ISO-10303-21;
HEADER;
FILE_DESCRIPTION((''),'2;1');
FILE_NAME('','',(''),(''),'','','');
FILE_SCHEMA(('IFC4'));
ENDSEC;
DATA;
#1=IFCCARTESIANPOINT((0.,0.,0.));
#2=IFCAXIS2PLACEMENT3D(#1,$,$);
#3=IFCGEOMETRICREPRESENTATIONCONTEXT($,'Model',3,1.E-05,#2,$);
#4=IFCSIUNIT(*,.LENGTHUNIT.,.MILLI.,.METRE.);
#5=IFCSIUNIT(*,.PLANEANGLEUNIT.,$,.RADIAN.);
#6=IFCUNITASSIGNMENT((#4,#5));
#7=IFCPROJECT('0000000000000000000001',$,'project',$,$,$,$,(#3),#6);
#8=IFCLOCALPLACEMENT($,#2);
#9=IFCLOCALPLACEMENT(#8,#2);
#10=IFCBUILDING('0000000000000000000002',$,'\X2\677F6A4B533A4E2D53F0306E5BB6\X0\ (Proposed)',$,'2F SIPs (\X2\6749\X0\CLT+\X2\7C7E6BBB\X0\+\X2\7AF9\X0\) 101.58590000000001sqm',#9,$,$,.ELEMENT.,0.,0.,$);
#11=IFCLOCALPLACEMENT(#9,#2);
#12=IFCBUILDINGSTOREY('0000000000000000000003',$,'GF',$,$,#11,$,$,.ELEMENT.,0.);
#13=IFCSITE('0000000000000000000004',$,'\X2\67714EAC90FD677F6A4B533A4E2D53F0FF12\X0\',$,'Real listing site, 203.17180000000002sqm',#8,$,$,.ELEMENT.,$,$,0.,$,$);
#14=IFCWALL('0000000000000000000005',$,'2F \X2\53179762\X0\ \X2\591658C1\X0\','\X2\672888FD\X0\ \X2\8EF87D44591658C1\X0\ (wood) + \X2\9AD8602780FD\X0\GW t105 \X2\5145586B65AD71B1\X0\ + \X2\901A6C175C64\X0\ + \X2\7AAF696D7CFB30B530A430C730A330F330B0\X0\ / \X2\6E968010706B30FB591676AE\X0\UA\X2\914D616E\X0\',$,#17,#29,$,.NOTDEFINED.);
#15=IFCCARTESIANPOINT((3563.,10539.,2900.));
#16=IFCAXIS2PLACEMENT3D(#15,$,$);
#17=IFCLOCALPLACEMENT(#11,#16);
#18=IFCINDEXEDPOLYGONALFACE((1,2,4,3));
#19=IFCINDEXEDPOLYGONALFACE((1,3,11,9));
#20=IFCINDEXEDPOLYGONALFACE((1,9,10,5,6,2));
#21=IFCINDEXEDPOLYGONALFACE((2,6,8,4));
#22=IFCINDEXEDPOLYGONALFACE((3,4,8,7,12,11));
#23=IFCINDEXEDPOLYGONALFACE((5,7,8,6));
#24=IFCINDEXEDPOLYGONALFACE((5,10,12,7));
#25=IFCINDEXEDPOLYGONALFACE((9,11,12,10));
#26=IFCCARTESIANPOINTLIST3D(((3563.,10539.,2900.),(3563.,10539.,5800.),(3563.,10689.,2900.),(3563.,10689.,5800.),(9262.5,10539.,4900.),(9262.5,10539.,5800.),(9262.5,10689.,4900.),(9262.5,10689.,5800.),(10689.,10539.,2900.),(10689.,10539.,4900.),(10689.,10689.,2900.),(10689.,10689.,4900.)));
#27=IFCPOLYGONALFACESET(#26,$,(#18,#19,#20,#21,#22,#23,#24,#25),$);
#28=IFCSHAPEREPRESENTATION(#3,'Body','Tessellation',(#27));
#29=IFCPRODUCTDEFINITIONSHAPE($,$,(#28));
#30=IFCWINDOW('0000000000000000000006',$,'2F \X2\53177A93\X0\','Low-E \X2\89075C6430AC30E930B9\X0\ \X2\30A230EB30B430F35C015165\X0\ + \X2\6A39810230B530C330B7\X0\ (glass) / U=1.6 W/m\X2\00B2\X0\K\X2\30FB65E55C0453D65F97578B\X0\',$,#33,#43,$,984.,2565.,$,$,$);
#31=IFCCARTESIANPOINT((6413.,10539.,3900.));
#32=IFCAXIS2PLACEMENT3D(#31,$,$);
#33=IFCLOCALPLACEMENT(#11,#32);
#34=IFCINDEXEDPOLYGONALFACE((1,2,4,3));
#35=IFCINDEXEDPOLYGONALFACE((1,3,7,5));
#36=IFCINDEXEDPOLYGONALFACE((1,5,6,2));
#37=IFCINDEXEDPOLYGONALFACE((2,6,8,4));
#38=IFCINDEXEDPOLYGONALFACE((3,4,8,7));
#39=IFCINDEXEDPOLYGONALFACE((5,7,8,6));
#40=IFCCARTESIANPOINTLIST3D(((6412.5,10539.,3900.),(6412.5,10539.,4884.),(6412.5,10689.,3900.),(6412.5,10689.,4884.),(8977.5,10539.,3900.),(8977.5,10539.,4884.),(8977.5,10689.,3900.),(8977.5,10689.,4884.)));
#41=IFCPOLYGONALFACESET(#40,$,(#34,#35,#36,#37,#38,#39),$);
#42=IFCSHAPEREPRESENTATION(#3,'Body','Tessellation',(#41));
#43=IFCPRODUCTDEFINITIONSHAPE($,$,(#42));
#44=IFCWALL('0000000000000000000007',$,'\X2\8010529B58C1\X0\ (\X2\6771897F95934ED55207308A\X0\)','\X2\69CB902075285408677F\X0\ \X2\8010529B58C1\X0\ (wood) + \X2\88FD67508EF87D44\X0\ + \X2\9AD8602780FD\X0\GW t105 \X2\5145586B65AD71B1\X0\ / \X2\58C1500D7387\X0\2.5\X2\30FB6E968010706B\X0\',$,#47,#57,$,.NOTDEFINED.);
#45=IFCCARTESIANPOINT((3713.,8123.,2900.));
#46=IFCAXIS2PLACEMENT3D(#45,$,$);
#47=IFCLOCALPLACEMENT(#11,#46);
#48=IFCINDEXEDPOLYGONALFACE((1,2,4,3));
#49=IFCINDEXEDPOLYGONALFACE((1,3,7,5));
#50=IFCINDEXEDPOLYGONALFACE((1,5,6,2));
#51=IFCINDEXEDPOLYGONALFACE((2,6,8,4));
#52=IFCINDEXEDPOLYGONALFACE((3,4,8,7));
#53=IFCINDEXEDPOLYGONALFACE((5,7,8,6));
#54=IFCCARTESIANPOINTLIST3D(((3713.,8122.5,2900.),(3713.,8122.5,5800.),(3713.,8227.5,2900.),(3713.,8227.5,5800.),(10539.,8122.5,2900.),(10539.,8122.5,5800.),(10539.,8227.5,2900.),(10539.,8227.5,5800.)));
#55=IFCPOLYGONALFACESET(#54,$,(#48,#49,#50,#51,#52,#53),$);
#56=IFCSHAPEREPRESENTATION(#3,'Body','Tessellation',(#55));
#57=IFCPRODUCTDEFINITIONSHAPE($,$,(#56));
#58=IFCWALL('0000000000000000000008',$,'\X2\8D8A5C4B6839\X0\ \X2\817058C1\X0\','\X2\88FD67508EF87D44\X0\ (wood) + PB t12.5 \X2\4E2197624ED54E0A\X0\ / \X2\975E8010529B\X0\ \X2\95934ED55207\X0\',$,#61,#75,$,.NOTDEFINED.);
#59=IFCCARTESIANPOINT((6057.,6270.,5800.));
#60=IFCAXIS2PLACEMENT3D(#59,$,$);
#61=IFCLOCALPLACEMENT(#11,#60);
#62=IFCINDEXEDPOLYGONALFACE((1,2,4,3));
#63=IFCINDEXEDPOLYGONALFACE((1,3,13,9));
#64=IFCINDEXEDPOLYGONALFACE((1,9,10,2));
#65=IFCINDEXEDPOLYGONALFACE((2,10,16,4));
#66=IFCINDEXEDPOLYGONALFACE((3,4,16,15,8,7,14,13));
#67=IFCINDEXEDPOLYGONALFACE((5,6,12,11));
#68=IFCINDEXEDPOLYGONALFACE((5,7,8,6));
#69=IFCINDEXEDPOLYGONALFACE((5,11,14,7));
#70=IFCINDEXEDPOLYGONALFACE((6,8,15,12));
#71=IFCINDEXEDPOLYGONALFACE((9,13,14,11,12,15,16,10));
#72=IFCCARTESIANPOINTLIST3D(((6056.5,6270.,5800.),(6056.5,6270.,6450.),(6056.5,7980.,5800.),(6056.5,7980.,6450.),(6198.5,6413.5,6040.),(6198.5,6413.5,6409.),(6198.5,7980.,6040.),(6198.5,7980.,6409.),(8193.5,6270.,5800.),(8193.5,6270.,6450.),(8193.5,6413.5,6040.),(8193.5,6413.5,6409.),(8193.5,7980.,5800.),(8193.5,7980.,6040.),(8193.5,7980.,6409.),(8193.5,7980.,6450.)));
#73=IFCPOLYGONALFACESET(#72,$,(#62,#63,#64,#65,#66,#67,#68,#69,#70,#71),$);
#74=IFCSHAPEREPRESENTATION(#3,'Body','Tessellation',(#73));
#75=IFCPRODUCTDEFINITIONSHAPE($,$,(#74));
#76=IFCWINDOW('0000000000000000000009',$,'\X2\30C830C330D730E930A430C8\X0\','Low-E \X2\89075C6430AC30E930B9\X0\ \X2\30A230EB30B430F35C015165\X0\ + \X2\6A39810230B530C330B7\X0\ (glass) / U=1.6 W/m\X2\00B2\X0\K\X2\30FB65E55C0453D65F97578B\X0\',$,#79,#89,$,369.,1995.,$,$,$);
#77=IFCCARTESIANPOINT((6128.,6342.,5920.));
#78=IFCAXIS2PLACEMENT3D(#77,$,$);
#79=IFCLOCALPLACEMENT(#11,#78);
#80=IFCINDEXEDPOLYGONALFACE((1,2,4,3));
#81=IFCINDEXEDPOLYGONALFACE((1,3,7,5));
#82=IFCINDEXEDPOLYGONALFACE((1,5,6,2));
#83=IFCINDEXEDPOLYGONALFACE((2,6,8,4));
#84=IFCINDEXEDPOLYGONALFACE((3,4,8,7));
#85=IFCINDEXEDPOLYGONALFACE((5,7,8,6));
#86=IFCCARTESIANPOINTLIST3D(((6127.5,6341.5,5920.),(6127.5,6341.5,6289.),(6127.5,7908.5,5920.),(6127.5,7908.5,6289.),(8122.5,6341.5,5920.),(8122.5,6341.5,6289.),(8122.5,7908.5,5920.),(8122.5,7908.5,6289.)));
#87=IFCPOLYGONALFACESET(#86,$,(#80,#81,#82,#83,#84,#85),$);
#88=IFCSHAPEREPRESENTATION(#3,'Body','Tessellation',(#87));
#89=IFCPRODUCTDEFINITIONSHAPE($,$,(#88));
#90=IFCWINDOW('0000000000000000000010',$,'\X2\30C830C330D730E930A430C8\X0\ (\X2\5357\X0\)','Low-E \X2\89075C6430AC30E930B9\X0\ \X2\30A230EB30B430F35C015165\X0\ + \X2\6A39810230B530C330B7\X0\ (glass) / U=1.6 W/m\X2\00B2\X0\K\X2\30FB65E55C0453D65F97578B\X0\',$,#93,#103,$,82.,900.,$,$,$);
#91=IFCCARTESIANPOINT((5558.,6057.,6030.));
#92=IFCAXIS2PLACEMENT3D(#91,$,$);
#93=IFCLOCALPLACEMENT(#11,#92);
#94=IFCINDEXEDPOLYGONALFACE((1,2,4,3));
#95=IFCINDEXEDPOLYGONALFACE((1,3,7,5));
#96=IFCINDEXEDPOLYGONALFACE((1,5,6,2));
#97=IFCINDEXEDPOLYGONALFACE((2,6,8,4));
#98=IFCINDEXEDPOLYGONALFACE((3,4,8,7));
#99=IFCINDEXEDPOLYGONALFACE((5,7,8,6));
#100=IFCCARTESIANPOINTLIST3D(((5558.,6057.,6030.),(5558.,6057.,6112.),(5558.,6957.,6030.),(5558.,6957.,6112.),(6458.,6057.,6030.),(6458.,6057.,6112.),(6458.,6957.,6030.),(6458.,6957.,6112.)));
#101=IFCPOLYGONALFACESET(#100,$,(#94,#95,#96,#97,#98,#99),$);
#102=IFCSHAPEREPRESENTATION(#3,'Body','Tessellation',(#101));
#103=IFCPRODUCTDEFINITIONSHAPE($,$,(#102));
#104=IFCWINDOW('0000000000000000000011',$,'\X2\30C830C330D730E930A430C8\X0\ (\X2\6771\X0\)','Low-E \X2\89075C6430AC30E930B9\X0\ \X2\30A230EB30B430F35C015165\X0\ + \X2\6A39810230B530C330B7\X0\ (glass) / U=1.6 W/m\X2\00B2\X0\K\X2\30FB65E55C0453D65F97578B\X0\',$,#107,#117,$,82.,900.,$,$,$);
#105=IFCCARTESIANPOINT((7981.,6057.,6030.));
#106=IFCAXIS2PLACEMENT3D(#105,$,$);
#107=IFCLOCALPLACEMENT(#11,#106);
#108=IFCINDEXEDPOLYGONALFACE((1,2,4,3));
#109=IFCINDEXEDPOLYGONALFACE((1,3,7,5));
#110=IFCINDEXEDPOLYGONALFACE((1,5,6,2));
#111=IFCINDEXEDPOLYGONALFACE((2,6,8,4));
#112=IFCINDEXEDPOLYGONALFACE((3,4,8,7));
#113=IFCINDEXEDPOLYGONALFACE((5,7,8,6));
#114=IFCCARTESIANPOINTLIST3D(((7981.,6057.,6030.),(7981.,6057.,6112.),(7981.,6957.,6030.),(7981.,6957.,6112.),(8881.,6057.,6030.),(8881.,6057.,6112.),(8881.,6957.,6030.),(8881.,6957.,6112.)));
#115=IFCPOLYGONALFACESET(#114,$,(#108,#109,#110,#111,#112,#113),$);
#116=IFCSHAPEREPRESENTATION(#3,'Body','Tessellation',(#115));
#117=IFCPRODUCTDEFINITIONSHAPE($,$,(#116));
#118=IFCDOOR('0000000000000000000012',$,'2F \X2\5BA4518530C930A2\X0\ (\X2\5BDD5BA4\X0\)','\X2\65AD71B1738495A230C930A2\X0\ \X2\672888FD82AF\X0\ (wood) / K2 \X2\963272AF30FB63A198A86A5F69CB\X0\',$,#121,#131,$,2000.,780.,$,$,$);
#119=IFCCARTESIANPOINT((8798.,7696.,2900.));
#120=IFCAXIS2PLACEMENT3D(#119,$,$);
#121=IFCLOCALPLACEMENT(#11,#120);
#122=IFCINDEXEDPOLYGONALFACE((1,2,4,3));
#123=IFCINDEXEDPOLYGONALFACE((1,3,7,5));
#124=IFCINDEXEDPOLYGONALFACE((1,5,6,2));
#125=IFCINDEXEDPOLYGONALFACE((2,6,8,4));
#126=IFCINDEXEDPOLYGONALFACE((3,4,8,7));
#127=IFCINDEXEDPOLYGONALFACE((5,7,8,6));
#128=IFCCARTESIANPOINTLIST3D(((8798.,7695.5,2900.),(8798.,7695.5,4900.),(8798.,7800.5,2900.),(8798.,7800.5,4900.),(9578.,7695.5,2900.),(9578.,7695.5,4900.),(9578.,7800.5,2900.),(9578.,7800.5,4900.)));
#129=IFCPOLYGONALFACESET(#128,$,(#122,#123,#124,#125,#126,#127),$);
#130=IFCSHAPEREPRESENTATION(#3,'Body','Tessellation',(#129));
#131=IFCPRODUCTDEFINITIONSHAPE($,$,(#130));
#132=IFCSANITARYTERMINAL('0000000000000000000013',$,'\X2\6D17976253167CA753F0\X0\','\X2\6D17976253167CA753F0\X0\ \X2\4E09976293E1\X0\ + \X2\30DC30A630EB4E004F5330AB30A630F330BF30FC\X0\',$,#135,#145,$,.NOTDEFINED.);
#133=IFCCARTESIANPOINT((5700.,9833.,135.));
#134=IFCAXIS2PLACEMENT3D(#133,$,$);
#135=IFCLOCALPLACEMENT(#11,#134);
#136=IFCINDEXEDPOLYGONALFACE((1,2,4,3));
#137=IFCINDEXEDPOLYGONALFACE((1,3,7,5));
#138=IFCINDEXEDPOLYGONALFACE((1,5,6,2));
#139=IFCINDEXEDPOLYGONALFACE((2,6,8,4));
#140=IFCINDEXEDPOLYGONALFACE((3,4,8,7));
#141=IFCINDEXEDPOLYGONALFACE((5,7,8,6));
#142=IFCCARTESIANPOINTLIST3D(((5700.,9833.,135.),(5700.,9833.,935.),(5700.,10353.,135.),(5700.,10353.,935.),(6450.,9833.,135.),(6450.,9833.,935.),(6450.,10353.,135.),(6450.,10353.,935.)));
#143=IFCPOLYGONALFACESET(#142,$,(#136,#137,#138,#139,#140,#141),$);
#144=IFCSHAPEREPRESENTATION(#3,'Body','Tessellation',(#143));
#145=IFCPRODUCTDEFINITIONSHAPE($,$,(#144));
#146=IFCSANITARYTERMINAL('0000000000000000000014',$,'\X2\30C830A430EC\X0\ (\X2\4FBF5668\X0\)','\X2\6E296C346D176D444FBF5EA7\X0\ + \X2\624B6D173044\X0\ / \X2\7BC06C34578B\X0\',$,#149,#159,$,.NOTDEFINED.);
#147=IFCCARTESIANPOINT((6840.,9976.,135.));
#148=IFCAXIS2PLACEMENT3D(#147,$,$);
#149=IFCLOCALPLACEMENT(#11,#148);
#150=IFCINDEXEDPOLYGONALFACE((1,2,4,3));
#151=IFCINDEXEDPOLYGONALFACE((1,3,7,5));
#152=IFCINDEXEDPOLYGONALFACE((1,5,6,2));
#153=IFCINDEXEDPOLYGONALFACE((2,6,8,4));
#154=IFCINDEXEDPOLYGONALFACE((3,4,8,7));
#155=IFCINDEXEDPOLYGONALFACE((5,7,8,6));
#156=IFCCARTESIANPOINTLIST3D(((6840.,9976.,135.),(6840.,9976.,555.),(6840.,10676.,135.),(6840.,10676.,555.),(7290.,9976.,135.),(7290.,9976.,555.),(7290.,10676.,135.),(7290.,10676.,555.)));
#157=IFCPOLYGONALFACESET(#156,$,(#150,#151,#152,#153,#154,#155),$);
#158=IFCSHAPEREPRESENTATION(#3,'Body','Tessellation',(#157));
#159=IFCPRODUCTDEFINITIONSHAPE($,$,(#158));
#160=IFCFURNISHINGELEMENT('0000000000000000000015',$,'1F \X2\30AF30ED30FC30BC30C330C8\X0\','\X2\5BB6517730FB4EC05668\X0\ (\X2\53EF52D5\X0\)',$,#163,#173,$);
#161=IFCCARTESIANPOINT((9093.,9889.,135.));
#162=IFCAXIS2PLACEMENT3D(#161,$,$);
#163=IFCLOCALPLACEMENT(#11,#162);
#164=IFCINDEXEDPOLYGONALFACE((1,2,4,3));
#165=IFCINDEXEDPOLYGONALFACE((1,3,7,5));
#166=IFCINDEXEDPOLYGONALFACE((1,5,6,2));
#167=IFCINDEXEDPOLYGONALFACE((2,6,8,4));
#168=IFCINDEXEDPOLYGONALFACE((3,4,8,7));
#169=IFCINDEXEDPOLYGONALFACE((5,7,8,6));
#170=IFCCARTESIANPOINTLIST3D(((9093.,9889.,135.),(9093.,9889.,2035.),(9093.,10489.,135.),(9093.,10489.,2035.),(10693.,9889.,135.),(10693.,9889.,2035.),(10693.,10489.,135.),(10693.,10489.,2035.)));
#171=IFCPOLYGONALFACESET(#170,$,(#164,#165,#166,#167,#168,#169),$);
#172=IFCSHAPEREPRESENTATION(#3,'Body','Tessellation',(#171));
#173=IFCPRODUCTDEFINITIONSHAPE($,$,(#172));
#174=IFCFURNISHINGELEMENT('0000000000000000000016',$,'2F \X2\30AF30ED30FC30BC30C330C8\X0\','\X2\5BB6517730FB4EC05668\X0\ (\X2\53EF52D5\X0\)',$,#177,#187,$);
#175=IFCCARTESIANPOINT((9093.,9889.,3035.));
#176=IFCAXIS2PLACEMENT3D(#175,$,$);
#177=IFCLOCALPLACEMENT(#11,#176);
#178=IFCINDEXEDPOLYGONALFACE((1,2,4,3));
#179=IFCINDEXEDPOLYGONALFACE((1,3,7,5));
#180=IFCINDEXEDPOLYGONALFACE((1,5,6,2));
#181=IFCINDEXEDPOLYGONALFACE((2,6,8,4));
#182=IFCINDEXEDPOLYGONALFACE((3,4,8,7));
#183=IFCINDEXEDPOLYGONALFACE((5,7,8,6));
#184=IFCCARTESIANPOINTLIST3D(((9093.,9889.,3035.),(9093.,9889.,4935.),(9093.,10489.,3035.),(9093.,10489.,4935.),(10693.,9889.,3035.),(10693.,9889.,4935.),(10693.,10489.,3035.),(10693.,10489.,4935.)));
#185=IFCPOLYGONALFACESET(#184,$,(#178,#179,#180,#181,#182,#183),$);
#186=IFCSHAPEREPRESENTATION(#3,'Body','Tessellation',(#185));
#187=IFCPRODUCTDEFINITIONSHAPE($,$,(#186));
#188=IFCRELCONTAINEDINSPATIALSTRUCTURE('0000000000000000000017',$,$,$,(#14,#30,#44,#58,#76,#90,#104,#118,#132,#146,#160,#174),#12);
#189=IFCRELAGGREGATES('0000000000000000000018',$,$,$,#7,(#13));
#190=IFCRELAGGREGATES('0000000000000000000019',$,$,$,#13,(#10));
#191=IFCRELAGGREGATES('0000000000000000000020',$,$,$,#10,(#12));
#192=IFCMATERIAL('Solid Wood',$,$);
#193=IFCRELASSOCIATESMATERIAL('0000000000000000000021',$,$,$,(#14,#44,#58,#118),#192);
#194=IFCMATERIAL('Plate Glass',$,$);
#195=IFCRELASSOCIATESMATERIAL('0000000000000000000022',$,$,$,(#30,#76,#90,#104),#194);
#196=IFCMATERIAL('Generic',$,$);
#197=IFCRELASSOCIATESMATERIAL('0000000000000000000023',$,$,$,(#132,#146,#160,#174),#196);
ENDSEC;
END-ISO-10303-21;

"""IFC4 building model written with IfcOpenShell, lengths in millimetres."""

from ifc_helpers import new_model, si_unit, frame, frame_2d, origin, place, context, project, spatial, rectangle, extrude, material, element, fill, save


model = new_model("IFC4")

# Units and contexts
model_context = context("Model", 3, precision=1e-05, world=origin())
ifc_project = project(units=[si_unit("LENGTHUNIT", "METRE", prefix="MILLI"), si_unit("PLANEANGLEUNIT", "RADIAN")], contexts=[model_context])

# Site, building, storey
site_placement = place(None, origin())
site = spatial("IfcSite", under=ifc_project, at=site_placement, Name="東京都板橋区中台２", ObjectType="Real listing site, 203.17180000000002sqm", CompositionType="ELEMENT", RefElevation=0.0)
building_placement = place(site_placement, origin())
building = spatial("IfcBuilding", under=site, at=building_placement, Name="板橋区中台の家 (Proposed)", ObjectType="2F SIPs (杉CLT+籾殻+竹) 101.58590000000001sqm", CompositionType="ELEMENT", ElevationOfRefHeight=0.0, ElevationOfTerrain=0.0)
storey_placement = place(building_placement, origin())
storey = spatial("IfcBuildingStorey", under=building, at=storey_placement, Name="GF", CompositionType="ELEMENT", Elevation=0.0)

# Wall, opening, window
ifc_material_1 = material(Name="Solid Wood")
wall_1_placement = place(storey_placement, frame((3563.0, 10539.0, 2900.0)))
wall_1 = element("IfcWall", 1, at=wall_1_placement, inside=storey, material=ifc_material_1, Name="2F 北面 外壁", Description="木製 軸組外壁 (wood) + 高性能GW t105 充填断熱 + 通気層 + 窯業系サイディング / 準耐火・外皮UA配慮", PredefinedType="NOTDEFINED", context=model_context, shape_type="SweptSolid", body=[
    extrude(rectangle(XDim=7126.0, YDim=150.0, at=frame_2d((3563.0, 75.0))), frame((3563.0, 10539.0, 2900.0)), (0.0, 0.0, 1.0), 2900.0),
])
opening_1_placement = place(storey_placement, frame((6413.0, 10539.0, 3900.0)))
opening_1 = element("IfcOpeningElement", 2, at=opening_1_placement, cuts=wall_1, PredefinedType="NOTDEFINED", context=model_context, shape_type="SweptSolid", body=[
    extrude(rectangle(XDim=2565.0, YDim=150.0, at=frame_2d((1282.0, 75.0))), frame((6413.0, 10539.0, 3900.0)), (0.0, 0.0, 1.0), 984.0),
])
ifc_material_2 = material(Name="Plate Glass")
window_1_placement = place(storey_placement, frame((6413.0, 10539.0, 3900.0)))
window_1 = element("IfcWindow", 3, at=window_1_placement, inside=storey, material=ifc_material_2, Name="2F 北窓", Description="Low-E 複層ガラス アルゴン封入 + 樹脂サッシ (glass) / U=1.6 W/m²K・日射取得型", OverallHeight=984.0, OverallWidth=2565.0, context=model_context, shape_type="SweptSolid", body=[
    extrude(rectangle(XDim=2565.0, YDim=150.0, at=frame_2d((1282.0, 75.0))), frame((6413.0, 10539.0, 3900.0)), (0.0, 0.0, 1.0), 984.0),
])
fill(opening_1, window_1)

# Wall
wall_2_placement = place(storey_placement, frame((3713.0, 8123.0, 2900.0)))
element("IfcWall", 4, at=wall_2_placement, inside=storey, material=ifc_material_1, Name="耐力壁 (東西間仕切り)", Description="構造用合板 耐力壁 (wood) + 製材軸組 + 高性能GW t105 充填断熱 / 壁倍率2.5・準耐火", PredefinedType="NOTDEFINED", context=model_context, shape_type="SweptSolid", body=[
    extrude(rectangle(XDim=6826.0, YDim=105.0, at=frame_2d((3413.0, 52.0))), frame((3713.0, 8123.0, 2900.0)), (0.0, 0.0, 1.0), 2900.0),
])

# Wall, openings, windows
wall_3_placement = place(storey_placement, frame((6057.0, 6270.0, 5800.0)))
wall_3 = element("IfcWall", 5, at=wall_3_placement, inside=storey, material=ifc_material_1, Name="越屋根 腰壁", Description="製材軸組 (wood) + PB t12.5 両面仕上 / 非耐力 間仕切", PredefinedType="NOTDEFINED", context=model_context, shape_type="SweptSolid", body=[
    extrude(rectangle(XDim=2137.0, YDim=1710.0, at=frame_2d((1068.0, 855.0))), frame((6057.0, 6270.0, 5800.0)), (0.0, 0.0, 1.0), 650.0),
])
opening_2_placement = place(storey_placement, frame((6128.0, 6342.0, 5920.0)))
opening_2 = element("IfcOpeningElement", 6, at=opening_2_placement, cuts=wall_3, PredefinedType="NOTDEFINED", context=model_context, shape_type="SweptSolid", body=[
    extrude(rectangle(XDim=1995.0, YDim=1567.0, at=frame_2d((997.0, 783.0))), frame((6128.0, 6342.0, 5920.0)), (0.0, 0.0, 1.0), 369.0),
])
opening_3_placement = place(storey_placement, frame((5558.0, 6057.0, 6030.0)))
opening_3 = element("IfcOpeningElement", 7, at=opening_3_placement, cuts=wall_3, PredefinedType="NOTDEFINED", context=model_context, shape_type="SweptSolid", body=[
    extrude(rectangle(XDim=900.0, YDim=900.0, at=frame_2d((450.0, 450.0))), frame((5558.0, 6057.0, 6030.0)), (0.0, 0.0, 1.0), 82.0),
])
opening_4_placement = place(storey_placement, frame((7981.0, 6057.0, 6030.0)))
opening_4 = element("IfcOpeningElement", 8, at=opening_4_placement, cuts=wall_3, PredefinedType="NOTDEFINED", context=model_context, shape_type="SweptSolid", body=[
    extrude(rectangle(XDim=900.0, YDim=900.0, at=frame_2d((450.0, 450.0))), frame((7981.0, 6057.0, 6030.0)), (0.0, 0.0, 1.0), 82.0),
])
window_2_placement = place(storey_placement, frame((6128.0, 6342.0, 5920.0)))
window_2 = element("IfcWindow", 9, at=window_2_placement, inside=storey, material=ifc_material_2, Name="トップライト", Description="Low-E 複層ガラス アルゴン封入 + 樹脂サッシ (glass) / U=1.6 W/m²K・日射取得型", OverallHeight=369.0, OverallWidth=1995.0, context=model_context, shape_type="SweptSolid", body=[
    extrude(rectangle(XDim=1995.0, YDim=1567.0, at=frame_2d((997.0, 783.0))), frame((6128.0, 6342.0, 5920.0)), (0.0, 0.0, 1.0), 369.0),
])
fill(opening_2, window_2)
window_3_placement = place(storey_placement, frame((5558.0, 6057.0, 6030.0)))
window_3 = element("IfcWindow", 10, at=window_3_placement, inside=storey, material=ifc_material_2, Name="トップライト (南)", Description="Low-E 複層ガラス アルゴン封入 + 樹脂サッシ (glass) / U=1.6 W/m²K・日射取得型", OverallHeight=82.0, OverallWidth=900.0, context=model_context, shape_type="SweptSolid", body=[
    extrude(rectangle(XDim=900.0, YDim=900.0, at=frame_2d((450.0, 450.0))), frame((5558.0, 6057.0, 6030.0)), (0.0, 0.0, 1.0), 82.0),
])
fill(opening_3, window_3)
window_4_placement = place(storey_placement, frame((7981.0, 6057.0, 6030.0)))
window_4 = element("IfcWindow", 11, at=window_4_placement, inside=storey, material=ifc_material_2, Name="トップライト (東)", Description="Low-E 複層ガラス アルゴン封入 + 樹脂サッシ (glass) / U=1.6 W/m²K・日射取得型", OverallHeight=82.0, OverallWidth=900.0, context=model_context, shape_type="SweptSolid", body=[
    extrude(rectangle(XDim=900.0, YDim=900.0, at=frame_2d((450.0, 450.0))), frame((7981.0, 6057.0, 6030.0)), (0.0, 0.0, 1.0), 82.0),
])
fill(opening_4, window_4)

# Door
door_placement = place(storey_placement, frame((8798.0, 7696.0, 2900.0)))
element("IfcDoor", 12, at=door_placement, inside=storey, material=ifc_material_1, Name="2F 室内ドア (寝室)", Description="断熱玄関ドア 木製芯 (wood) / K2 防犯・採風機構", OverallHeight=2000.0, OverallWidth=780.0, context=model_context, shape_type="SweptSolid", body=[
    extrude(rectangle(XDim=780.0, YDim=105.0, at=frame_2d((390.0, 52.0))), frame((8798.0, 7696.0, 2900.0)), (0.0, 0.0, 1.0), 2000.0),
])

# Sanitary terminals
ifc_material_3 = material(Name="Generic")
sanitary_terminal_1_placement = place(storey_placement, frame((5700.0, 9833.0, 135.0)))
element("IfcSanitaryTerminal", 13, at=sanitary_terminal_1_placement, inside=storey, material=ifc_material_3, Name="洗面化粧台", Description="洗面化粧台 三面鏡 + ボウル一体カウンター", PredefinedType="NOTDEFINED", context=model_context, shape_type="SweptSolid", body=[
    extrude(rectangle(XDim=750.0, YDim=520.0, at=frame_2d((375.0, 260.0))), frame((5700.0, 9833.0, 135.0)), (0.0, 0.0, 1.0), 800.0),
])
sanitary_terminal_2_placement = place(storey_placement, frame((6840.0, 9976.0, 135.0)))
element("IfcSanitaryTerminal", 14, at=sanitary_terminal_2_placement, inside=storey, material=ifc_material_3, Name="トイレ (便器)", Description="温水洗浄便座 + 手洗い / 節水型", PredefinedType="NOTDEFINED", context=model_context, shape_type="SweptSolid", body=[
    extrude(rectangle(XDim=450.0, YDim=700.0, at=frame_2d((225.0, 350.0))), frame((6840.0, 9976.0, 135.0)), (0.0, 0.0, 1.0), 420.0),
])

# Furnishing elements
furnishing_1_placement = place(storey_placement, frame((9093.0, 9889.0, 135.0)))
element("IfcFurnishingElement", 15, at=furnishing_1_placement, inside=storey, material=ifc_material_3, Name="1F クローゼット", Description="家具・什器 (可動)", context=model_context, shape_type="SweptSolid", body=[
    extrude(rectangle(XDim=1600.0, YDim=600.0, at=frame_2d((800.0, 300.0))), frame((9093.0, 9889.0, 135.0)), (0.0, 0.0, 1.0), 1900.0),
])
furnishing_2_placement = place(storey_placement, frame((9093.0, 9889.0, 3035.0)))
element("IfcFurnishingElement", 16, at=furnishing_2_placement, inside=storey, material=ifc_material_3, Name="2F クローゼット", Description="家具・什器 (可動)", context=model_context, shape_type="SweptSolid", body=[
    extrude(rectangle(XDim=1600.0, YDim=600.0, at=frame_2d((800.0, 300.0))), frame((9093.0, 9889.0, 3035.0)), (0.0, 0.0, 1.0), 1900.0),
])

save(model, "model.ifc")
